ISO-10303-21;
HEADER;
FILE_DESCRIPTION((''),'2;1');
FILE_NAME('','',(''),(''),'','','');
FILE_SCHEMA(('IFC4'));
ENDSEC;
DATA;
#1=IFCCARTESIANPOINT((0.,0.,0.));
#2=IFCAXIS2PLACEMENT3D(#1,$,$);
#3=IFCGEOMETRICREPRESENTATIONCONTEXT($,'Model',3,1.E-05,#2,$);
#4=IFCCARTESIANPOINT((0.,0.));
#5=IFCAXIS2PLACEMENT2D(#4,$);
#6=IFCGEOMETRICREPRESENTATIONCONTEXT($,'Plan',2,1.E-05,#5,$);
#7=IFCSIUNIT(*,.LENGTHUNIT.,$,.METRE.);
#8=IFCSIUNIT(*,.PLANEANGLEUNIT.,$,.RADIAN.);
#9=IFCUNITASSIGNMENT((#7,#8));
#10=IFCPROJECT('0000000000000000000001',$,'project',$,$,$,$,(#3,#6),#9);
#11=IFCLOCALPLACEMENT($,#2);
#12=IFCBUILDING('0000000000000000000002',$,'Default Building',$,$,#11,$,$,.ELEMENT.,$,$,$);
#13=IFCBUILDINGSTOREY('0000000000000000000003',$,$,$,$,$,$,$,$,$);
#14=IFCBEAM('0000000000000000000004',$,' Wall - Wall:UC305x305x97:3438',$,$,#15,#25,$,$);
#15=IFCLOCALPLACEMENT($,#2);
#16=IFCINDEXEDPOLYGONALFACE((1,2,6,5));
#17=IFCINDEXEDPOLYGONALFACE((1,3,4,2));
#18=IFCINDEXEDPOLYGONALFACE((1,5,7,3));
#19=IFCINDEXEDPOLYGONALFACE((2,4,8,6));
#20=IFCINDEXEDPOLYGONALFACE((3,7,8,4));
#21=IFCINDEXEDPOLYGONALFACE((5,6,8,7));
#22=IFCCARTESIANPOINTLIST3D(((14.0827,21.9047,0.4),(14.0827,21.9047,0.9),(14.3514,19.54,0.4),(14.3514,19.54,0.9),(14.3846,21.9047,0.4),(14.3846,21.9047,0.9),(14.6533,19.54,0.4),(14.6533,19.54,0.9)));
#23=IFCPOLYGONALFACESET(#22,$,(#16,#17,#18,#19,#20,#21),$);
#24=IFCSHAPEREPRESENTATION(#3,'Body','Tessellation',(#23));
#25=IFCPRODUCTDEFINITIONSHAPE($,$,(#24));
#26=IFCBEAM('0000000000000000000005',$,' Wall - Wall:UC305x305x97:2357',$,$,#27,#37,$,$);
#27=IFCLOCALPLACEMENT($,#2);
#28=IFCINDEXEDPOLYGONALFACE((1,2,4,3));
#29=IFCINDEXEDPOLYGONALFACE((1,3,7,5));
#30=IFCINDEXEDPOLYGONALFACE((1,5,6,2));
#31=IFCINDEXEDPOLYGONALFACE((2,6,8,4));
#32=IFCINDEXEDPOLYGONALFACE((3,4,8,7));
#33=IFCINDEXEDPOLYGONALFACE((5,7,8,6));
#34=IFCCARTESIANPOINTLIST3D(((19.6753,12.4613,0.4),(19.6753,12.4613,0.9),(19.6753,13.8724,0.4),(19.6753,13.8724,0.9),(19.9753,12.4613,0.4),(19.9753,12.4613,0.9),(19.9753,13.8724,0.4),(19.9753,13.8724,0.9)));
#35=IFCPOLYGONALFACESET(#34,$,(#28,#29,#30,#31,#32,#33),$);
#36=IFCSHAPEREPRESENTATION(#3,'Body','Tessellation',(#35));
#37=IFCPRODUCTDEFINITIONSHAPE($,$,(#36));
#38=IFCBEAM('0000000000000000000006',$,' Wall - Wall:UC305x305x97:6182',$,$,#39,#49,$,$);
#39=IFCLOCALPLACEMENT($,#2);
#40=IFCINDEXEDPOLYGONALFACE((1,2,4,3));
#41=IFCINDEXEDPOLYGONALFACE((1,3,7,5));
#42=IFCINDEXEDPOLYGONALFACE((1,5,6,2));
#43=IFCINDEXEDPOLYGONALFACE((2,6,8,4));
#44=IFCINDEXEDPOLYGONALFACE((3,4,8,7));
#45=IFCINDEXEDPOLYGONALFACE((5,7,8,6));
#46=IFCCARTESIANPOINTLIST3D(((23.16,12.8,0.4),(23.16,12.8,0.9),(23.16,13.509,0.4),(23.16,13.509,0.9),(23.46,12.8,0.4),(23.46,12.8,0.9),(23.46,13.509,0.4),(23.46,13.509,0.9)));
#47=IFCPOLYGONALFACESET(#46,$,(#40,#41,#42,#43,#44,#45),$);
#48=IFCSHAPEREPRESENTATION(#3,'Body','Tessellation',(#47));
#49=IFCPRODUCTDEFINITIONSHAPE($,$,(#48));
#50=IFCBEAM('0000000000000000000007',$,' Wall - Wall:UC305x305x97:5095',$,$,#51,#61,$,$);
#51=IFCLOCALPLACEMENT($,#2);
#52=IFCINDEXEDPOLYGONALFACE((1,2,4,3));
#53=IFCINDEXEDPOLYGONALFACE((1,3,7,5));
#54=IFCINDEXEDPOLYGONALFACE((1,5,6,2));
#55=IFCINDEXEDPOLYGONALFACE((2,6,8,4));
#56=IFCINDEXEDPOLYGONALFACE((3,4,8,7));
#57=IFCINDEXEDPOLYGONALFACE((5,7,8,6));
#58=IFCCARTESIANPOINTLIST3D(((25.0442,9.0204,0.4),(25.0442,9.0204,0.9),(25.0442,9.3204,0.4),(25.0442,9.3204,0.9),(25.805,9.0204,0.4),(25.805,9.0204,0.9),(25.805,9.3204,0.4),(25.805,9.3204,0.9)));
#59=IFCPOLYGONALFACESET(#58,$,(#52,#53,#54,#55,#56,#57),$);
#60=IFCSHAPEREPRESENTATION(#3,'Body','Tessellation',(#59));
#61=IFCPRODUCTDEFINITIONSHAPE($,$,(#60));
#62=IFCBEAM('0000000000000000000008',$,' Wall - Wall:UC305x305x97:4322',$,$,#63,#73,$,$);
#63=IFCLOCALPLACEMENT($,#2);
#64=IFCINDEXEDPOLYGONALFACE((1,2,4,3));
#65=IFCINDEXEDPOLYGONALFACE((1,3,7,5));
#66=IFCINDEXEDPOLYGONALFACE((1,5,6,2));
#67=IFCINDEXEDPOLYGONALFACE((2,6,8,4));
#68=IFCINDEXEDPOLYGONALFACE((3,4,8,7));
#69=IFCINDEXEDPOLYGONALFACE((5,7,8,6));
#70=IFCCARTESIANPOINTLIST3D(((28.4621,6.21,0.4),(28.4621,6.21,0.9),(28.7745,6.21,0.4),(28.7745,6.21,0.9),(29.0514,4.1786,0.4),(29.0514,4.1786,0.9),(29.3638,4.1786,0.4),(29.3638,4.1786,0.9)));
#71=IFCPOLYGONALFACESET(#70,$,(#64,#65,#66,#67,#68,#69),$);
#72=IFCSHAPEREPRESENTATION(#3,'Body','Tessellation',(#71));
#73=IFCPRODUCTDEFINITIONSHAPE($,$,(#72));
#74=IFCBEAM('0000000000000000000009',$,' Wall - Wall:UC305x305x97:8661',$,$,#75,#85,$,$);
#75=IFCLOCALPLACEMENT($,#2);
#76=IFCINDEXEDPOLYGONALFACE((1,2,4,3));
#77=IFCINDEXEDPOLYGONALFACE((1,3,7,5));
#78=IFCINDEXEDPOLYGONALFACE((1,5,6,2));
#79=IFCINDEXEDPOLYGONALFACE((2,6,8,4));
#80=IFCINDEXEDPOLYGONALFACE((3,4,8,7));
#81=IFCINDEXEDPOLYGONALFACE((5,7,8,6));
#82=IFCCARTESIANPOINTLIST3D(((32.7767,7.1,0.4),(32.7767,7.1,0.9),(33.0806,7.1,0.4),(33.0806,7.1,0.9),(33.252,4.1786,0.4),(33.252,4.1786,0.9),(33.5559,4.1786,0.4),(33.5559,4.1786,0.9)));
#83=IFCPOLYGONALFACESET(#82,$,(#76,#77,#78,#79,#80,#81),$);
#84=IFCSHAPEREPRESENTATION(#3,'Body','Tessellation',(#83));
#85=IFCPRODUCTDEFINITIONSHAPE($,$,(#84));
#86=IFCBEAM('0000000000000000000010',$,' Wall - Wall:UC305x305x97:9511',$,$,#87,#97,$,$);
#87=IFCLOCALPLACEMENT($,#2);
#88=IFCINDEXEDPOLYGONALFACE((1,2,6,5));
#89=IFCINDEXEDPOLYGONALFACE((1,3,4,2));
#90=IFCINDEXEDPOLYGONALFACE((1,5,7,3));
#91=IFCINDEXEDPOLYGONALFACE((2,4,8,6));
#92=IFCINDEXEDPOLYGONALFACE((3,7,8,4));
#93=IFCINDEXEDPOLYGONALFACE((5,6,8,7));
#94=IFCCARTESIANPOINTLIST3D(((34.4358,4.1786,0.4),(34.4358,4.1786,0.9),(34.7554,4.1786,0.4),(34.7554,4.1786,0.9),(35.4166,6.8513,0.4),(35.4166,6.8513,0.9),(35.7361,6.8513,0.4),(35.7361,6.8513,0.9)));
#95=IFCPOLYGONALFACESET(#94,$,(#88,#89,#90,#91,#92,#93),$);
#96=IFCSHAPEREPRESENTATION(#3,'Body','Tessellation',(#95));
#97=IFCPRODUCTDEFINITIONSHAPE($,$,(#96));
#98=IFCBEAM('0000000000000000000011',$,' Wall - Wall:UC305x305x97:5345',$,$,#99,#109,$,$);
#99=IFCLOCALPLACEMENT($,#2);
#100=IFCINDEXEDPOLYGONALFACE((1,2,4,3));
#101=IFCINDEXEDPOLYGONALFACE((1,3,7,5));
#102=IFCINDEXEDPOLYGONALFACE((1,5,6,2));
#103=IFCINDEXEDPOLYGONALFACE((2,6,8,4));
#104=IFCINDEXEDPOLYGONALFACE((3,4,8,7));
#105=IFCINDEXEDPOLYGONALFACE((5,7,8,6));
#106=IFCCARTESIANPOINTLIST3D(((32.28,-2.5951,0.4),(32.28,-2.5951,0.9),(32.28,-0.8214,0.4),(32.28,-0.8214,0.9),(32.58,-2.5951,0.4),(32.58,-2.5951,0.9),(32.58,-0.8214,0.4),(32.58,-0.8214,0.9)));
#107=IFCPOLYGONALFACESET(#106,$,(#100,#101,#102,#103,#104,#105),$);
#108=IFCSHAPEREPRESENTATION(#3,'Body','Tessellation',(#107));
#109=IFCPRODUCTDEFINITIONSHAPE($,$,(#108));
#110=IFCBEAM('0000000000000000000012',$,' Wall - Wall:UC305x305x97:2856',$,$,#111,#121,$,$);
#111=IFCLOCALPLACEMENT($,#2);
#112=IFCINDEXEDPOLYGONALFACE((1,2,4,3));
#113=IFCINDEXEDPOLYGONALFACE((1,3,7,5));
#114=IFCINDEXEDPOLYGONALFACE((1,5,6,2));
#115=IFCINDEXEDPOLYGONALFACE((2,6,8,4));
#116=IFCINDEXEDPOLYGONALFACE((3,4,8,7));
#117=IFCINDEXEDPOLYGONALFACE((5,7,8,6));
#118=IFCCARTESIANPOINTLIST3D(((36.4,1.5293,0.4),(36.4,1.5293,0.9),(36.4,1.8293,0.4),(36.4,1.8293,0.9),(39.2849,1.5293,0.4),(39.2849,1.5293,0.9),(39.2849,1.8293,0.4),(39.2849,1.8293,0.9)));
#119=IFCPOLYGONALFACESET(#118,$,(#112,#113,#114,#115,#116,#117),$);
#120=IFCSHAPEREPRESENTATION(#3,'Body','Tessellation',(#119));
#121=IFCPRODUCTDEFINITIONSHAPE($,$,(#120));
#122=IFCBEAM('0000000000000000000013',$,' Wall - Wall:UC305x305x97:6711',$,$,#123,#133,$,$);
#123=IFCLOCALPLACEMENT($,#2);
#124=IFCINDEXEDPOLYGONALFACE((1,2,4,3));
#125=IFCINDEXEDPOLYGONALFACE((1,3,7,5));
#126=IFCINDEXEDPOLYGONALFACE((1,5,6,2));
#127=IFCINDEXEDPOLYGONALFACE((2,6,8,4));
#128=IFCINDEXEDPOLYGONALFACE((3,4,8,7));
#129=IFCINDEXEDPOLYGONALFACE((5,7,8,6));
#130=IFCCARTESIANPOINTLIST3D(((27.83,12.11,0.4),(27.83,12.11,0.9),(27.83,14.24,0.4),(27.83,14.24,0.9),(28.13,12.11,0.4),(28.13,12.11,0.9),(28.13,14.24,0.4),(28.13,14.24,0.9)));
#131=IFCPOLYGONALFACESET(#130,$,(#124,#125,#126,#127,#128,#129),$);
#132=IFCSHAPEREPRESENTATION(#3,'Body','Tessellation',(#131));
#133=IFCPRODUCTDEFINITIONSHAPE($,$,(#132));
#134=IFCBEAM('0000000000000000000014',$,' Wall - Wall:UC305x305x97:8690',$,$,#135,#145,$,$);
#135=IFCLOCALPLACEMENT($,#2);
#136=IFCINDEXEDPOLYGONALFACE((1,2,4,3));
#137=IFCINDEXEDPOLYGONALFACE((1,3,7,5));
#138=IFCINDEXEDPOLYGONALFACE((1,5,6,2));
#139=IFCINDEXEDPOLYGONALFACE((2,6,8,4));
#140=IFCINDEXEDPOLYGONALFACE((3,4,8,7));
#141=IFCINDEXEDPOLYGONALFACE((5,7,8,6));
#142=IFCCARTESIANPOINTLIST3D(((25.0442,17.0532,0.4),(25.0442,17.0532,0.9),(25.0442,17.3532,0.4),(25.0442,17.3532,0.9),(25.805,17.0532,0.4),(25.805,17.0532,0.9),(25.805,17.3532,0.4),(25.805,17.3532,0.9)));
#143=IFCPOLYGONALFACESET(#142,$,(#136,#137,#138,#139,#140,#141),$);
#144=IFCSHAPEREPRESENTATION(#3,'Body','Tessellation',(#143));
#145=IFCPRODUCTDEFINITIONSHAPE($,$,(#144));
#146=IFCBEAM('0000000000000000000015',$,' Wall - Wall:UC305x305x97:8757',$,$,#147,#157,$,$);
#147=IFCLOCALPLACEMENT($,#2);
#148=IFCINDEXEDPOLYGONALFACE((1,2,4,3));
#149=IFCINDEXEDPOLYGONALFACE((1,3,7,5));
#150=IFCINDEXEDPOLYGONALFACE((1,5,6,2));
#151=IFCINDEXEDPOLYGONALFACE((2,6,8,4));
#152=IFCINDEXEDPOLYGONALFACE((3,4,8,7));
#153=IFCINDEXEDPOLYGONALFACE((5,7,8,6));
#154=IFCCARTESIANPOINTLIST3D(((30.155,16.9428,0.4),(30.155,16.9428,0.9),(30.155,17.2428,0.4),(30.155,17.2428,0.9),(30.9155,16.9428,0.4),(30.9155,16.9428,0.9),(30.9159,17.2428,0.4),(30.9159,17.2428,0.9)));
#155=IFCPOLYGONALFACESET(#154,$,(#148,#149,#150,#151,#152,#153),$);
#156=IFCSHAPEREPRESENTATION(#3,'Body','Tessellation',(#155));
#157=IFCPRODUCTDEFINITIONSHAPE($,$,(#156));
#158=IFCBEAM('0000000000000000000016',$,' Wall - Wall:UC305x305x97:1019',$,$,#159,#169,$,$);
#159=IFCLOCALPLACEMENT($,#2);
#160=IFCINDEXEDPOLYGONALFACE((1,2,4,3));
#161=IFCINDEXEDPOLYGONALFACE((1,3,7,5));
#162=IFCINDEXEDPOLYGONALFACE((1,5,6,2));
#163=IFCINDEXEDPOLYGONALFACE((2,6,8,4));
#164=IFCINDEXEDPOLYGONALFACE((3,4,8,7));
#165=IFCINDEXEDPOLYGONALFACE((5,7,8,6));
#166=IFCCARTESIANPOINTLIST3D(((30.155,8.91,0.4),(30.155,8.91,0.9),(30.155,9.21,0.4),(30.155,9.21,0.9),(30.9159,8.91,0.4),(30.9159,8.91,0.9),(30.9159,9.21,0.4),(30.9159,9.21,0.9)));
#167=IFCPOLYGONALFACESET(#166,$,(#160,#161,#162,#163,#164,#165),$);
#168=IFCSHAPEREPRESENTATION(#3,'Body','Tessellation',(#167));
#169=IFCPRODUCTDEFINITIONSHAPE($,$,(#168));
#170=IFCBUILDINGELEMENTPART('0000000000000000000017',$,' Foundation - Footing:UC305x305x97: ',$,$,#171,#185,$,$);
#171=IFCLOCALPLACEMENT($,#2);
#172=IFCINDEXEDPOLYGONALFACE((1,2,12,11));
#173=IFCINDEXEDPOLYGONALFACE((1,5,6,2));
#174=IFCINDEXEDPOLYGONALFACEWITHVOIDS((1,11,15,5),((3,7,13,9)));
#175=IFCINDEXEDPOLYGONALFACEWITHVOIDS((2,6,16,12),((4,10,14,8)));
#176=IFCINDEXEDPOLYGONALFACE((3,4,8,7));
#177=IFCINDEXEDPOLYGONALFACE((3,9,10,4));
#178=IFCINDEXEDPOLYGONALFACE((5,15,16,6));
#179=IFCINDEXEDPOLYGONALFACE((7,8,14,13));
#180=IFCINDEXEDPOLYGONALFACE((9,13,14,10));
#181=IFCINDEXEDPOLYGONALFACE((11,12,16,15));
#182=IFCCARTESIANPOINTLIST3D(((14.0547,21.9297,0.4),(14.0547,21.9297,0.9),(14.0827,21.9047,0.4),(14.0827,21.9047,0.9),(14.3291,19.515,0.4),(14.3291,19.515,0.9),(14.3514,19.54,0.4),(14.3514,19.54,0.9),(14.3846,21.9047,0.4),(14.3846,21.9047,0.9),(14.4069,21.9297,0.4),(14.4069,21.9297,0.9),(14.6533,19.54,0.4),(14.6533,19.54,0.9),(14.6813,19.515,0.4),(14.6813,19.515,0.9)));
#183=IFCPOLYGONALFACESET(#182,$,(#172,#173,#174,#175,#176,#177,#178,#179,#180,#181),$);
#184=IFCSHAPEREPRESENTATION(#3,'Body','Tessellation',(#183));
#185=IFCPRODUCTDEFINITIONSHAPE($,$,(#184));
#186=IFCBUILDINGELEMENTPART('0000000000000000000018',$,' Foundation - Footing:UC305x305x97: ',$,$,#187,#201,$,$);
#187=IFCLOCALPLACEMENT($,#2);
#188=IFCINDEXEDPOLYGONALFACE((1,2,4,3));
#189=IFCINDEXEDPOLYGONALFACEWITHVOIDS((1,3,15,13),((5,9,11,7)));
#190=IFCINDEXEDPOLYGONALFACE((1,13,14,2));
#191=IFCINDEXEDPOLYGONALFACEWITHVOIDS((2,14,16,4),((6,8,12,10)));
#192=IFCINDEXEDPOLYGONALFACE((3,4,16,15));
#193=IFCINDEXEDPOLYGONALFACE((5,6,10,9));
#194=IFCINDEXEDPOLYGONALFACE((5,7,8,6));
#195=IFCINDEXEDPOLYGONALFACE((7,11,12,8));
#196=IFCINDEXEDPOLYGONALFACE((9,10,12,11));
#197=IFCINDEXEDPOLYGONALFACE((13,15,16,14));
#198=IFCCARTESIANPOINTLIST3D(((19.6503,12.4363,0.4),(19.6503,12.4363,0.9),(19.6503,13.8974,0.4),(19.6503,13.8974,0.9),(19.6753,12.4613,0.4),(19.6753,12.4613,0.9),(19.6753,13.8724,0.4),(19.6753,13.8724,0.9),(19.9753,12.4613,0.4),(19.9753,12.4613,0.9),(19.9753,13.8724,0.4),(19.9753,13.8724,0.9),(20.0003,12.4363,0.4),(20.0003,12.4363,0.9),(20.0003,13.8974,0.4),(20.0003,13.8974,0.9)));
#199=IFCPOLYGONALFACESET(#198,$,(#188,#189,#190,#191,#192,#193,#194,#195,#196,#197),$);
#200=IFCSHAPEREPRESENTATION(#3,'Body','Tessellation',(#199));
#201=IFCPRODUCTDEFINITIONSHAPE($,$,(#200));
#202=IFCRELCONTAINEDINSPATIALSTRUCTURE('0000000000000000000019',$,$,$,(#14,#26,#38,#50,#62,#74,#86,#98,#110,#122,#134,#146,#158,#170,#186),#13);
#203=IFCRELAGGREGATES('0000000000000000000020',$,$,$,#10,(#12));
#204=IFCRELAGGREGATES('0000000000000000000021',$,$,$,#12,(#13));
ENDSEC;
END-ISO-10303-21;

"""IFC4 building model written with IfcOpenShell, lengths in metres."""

from ifc_helpers import new_model, si_unit, origin, origin_2d, place, context, project, spatial, polyline, outline, extrude, element, save


model = new_model("IFC4")

# Units and contexts
model_context = context("Model", 3, precision=1e-05, world=origin())
plan_context = context("Plan", 2, precision=1e-05, world=origin_2d())
ifc_project = project(units=[si_unit("LENGTHUNIT", "METRE"), si_unit("PLANEANGLEUNIT", "RADIAN")], contexts=[model_context, plan_context])

# Building, storey
building_placement = place(None, origin())
building = spatial("IfcBuilding", under=ifc_project, at=building_placement, Name="Default Building", CompositionType="ELEMENT")
storey = spatial("IfcBuildingStorey", under=building)

# Beams
element("IfcBeam", 1, inside=storey, Name=" Wall - Wall:UC305x305x97:3438", context=model_context, shape_type="SweptSolid", body=[
    extrude(outline(polyline([(14.3514, 19.54, 0.4), (14.6533, 19.54, 0.4), (14.3846, 21.9047, 0.4), (14.0827, 21.9047, 0.4), (14.3514, 19.54, 0.4)])), None, (0.0, 0.0, 1.0), 0.5),
])
element("IfcBeam", 2, inside=storey, Name=" Wall - Wall:UC305x305x97:2357", context=model_context, shape_type="SweptSolid", body=[
    extrude(outline(polyline([(19.6753, 12.4613, 0.4), (19.9753, 12.4613, 0.4), (19.9753, 13.8724, 0.4), (19.6753, 13.8724, 0.4), (19.6753, 12.4613, 0.4)])), None, (0.0, 0.0, 1.0), 0.5),
])
element("IfcBeam", 3, inside=storey, Name=" Wall - Wall:UC305x305x97:6182", context=model_context, shape_type="SweptSolid", body=[
    extrude(outline(polyline([(23.16, 12.8, 0.4), (23.46, 12.8, 0.4), (23.46, 13.509, 0.4), (23.16, 13.509, 0.4), (23.16, 12.8, 0.4)])), None, (0.0, 0.0, 1.0), 0.5),
])
element("IfcBeam", 4, inside=storey, Name=" Wall - Wall:UC305x305x97:5095", context=model_context, shape_type="SweptSolid", body=[
    extrude(outline(polyline([(25.0442, 9.0204, 0.4), (25.805, 9.0204, 0.4), (25.805, 9.3204, 0.4), (25.0442, 9.3204, 0.4), (25.0442, 9.0204, 0.4)])), None, (0.0, 0.0, 1.0), 0.5),
])
element("IfcBeam", 5, inside=storey, Name=" Wall - Wall:UC305x305x97:4322", context=model_context, shape_type="SweptSolid", body=[
    extrude(outline(polyline([(29.0514, 4.1786, 0.4), (29.3638, 4.1786, 0.4), (28.7745, 6.21, 0.4), (28.4621, 6.21, 0.4), (29.0514, 4.1786, 0.4)])), None, (0.0, 0.0, 1.0), 0.5),
])
element("IfcBeam", 6, inside=storey, Name=" Wall - Wall:UC305x305x97:8661", context=model_context, shape_type="SweptSolid", body=[
    extrude(outline(polyline([(33.252, 4.1786, 0.4), (33.5559, 4.1786, 0.4), (33.0806, 7.1, 0.4), (32.7767, 7.1, 0.4), (33.252, 4.1786, 0.4)])), None, (0.0, 0.0, 1.0), 0.5),
])
element("IfcBeam", 7, inside=storey, Name=" Wall - Wall:UC305x305x97:9511", context=model_context, shape_type="SweptSolid", body=[
    extrude(outline(polyline([(34.4358, 4.1786, 0.4), (34.7554, 4.1786, 0.4), (35.7361, 6.8513, 0.4), (35.4166, 6.8513, 0.4), (34.4358, 4.1786, 0.4)])), None, (0.0, 0.0, 1.0), 0.5),
])
element("IfcBeam", 8, inside=storey, Name=" Wall - Wall:UC305x305x97:5345", context=model_context, shape_type="SweptSolid", body=[
    extrude(outline(polyline([(32.28, -2.5951, 0.4), (32.58, -2.5951, 0.4), (32.58, -0.8214, 0.4), (32.28, -0.8214, 0.4), (32.28, -2.5951, 0.4)])), None, (0.0, 0.0, 1.0), 0.5),
])
element("IfcBeam", 9, inside=storey, Name=" Wall - Wall:UC305x305x97:2856", context=model_context, shape_type="SweptSolid", body=[
    extrude(outline(polyline([(36.4, 1.5293, 0.4), (36.4, 1.8293, 0.4), (39.2849, 1.8293, 0.4), (39.2849, 1.5293, 0.4), (36.4, 1.5293, 0.4)])), None, (0.0, 0.0, 1.0), 0.5),
])
element("IfcBeam", 10, inside=storey, Name=" Wall - Wall:UC305x305x97:6711", context=model_context, shape_type="SweptSolid", body=[
    extrude(outline(polyline([(27.83, 12.11, 0.4), (28.13, 12.11, 0.4), (28.13, 14.24, 0.4), (27.83, 14.24, 0.4), (27.83, 12.11, 0.4)])), None, (0.0, 0.0, 1.0), 0.5),
])
element("IfcBeam", 11, inside=storey, Name=" Wall - Wall:UC305x305x97:8690", context=model_context, shape_type="SweptSolid", body=[
    extrude(outline(polyline([(25.0442, 17.0532, 0.4), (25.0442, 17.3532, 0.4), (25.805, 17.3532, 0.4), (25.805, 17.0532, 0.4), (25.0442, 17.0532, 0.4)])), None, (0.0, 0.0, 1.0), 0.5),
])
element("IfcBeam", 12, inside=storey, Name=" Wall - Wall:UC305x305x97:8757", context=model_context, shape_type="SweptSolid", body=[
    extrude(outline(polyline([(30.155, 16.9428, 0.4), (30.9155, 16.9428, 0.4), (30.9159, 17.2428, 0.4), (30.155, 17.2428, 0.4), (30.155, 16.9428, 0.4)])), None, (0.0, 0.0, 1.0), 0.5),
])
element("IfcBeam", 13, inside=storey, Name=" Wall - Wall:UC305x305x97:1019", context=model_context, shape_type="SweptSolid", body=[
    extrude(outline(polyline([(30.155, 8.91, 0.4), (30.9159, 8.91, 0.4), (30.9159, 9.21, 0.4), (30.155, 9.21, 0.4), (30.155, 8.91, 0.4)])), None, (0.0, 0.0, 1.0), 0.5),
])

# Building element parts, openings
building_element_part_1 = element("IfcBuildingElementPart", 14, inside=storey, Name=" Foundation - Footing:UC305x305x97: ", context=model_context, shape_type="SweptSolid", body=[
    extrude(outline(polyline([(14.3291, 19.515, 0.4), (14.6813, 19.515, 0.4), (14.4069, 21.9297, 0.4), (14.0547, 21.9297, 0.4), (14.3291, 19.515, 0.4)])), None, (0.0, 0.0, 1.0), 0.5),
])
element("IfcOpeningElement", 15, inside=storey, cuts=building_element_part_1, context=model_context, shape_type="SweptSolid", body=[
    extrude(outline(polyline([(14.3514, 19.54, 0.4), (14.6533, 19.54, 0.4), (14.3846, 21.9047, 0.4), (14.0827, 21.9047, 0.4), (14.3514, 19.54, 0.4)])), None, (0.0, 0.0, 1.0), 0.5),
])
building_element_part_2 = element("IfcBuildingElementPart", 16, inside=storey, Name=" Foundation - Footing:UC305x305x97: ", context=model_context, shape_type="SweptSolid", body=[
    extrude(outline(polyline([(19.6503, 12.4363, 0.4), (20.0003, 12.4363, 0.4), (20.0003, 13.8974, 0.4), (19.6503, 13.8974, 0.4), (19.6503, 12.4363, 0.4)])), None, (0.0, 0.0, 1.0), 0.5),
])
element("IfcOpeningElement", 17, inside=storey, cuts=building_element_part_2, context=model_context, shape_type="SweptSolid", body=[
    extrude(outline(polyline([(19.6753, 12.4613, 0.4), (19.9753, 12.4613, 0.4), (19.9753, 13.8724, 0.4), (19.6753, 13.8724, 0.4), (19.6753, 12.4613, 0.4)])), None, (0.0, 0.0, 1.0), 0.5),
])

save(model, "model.ifc")
